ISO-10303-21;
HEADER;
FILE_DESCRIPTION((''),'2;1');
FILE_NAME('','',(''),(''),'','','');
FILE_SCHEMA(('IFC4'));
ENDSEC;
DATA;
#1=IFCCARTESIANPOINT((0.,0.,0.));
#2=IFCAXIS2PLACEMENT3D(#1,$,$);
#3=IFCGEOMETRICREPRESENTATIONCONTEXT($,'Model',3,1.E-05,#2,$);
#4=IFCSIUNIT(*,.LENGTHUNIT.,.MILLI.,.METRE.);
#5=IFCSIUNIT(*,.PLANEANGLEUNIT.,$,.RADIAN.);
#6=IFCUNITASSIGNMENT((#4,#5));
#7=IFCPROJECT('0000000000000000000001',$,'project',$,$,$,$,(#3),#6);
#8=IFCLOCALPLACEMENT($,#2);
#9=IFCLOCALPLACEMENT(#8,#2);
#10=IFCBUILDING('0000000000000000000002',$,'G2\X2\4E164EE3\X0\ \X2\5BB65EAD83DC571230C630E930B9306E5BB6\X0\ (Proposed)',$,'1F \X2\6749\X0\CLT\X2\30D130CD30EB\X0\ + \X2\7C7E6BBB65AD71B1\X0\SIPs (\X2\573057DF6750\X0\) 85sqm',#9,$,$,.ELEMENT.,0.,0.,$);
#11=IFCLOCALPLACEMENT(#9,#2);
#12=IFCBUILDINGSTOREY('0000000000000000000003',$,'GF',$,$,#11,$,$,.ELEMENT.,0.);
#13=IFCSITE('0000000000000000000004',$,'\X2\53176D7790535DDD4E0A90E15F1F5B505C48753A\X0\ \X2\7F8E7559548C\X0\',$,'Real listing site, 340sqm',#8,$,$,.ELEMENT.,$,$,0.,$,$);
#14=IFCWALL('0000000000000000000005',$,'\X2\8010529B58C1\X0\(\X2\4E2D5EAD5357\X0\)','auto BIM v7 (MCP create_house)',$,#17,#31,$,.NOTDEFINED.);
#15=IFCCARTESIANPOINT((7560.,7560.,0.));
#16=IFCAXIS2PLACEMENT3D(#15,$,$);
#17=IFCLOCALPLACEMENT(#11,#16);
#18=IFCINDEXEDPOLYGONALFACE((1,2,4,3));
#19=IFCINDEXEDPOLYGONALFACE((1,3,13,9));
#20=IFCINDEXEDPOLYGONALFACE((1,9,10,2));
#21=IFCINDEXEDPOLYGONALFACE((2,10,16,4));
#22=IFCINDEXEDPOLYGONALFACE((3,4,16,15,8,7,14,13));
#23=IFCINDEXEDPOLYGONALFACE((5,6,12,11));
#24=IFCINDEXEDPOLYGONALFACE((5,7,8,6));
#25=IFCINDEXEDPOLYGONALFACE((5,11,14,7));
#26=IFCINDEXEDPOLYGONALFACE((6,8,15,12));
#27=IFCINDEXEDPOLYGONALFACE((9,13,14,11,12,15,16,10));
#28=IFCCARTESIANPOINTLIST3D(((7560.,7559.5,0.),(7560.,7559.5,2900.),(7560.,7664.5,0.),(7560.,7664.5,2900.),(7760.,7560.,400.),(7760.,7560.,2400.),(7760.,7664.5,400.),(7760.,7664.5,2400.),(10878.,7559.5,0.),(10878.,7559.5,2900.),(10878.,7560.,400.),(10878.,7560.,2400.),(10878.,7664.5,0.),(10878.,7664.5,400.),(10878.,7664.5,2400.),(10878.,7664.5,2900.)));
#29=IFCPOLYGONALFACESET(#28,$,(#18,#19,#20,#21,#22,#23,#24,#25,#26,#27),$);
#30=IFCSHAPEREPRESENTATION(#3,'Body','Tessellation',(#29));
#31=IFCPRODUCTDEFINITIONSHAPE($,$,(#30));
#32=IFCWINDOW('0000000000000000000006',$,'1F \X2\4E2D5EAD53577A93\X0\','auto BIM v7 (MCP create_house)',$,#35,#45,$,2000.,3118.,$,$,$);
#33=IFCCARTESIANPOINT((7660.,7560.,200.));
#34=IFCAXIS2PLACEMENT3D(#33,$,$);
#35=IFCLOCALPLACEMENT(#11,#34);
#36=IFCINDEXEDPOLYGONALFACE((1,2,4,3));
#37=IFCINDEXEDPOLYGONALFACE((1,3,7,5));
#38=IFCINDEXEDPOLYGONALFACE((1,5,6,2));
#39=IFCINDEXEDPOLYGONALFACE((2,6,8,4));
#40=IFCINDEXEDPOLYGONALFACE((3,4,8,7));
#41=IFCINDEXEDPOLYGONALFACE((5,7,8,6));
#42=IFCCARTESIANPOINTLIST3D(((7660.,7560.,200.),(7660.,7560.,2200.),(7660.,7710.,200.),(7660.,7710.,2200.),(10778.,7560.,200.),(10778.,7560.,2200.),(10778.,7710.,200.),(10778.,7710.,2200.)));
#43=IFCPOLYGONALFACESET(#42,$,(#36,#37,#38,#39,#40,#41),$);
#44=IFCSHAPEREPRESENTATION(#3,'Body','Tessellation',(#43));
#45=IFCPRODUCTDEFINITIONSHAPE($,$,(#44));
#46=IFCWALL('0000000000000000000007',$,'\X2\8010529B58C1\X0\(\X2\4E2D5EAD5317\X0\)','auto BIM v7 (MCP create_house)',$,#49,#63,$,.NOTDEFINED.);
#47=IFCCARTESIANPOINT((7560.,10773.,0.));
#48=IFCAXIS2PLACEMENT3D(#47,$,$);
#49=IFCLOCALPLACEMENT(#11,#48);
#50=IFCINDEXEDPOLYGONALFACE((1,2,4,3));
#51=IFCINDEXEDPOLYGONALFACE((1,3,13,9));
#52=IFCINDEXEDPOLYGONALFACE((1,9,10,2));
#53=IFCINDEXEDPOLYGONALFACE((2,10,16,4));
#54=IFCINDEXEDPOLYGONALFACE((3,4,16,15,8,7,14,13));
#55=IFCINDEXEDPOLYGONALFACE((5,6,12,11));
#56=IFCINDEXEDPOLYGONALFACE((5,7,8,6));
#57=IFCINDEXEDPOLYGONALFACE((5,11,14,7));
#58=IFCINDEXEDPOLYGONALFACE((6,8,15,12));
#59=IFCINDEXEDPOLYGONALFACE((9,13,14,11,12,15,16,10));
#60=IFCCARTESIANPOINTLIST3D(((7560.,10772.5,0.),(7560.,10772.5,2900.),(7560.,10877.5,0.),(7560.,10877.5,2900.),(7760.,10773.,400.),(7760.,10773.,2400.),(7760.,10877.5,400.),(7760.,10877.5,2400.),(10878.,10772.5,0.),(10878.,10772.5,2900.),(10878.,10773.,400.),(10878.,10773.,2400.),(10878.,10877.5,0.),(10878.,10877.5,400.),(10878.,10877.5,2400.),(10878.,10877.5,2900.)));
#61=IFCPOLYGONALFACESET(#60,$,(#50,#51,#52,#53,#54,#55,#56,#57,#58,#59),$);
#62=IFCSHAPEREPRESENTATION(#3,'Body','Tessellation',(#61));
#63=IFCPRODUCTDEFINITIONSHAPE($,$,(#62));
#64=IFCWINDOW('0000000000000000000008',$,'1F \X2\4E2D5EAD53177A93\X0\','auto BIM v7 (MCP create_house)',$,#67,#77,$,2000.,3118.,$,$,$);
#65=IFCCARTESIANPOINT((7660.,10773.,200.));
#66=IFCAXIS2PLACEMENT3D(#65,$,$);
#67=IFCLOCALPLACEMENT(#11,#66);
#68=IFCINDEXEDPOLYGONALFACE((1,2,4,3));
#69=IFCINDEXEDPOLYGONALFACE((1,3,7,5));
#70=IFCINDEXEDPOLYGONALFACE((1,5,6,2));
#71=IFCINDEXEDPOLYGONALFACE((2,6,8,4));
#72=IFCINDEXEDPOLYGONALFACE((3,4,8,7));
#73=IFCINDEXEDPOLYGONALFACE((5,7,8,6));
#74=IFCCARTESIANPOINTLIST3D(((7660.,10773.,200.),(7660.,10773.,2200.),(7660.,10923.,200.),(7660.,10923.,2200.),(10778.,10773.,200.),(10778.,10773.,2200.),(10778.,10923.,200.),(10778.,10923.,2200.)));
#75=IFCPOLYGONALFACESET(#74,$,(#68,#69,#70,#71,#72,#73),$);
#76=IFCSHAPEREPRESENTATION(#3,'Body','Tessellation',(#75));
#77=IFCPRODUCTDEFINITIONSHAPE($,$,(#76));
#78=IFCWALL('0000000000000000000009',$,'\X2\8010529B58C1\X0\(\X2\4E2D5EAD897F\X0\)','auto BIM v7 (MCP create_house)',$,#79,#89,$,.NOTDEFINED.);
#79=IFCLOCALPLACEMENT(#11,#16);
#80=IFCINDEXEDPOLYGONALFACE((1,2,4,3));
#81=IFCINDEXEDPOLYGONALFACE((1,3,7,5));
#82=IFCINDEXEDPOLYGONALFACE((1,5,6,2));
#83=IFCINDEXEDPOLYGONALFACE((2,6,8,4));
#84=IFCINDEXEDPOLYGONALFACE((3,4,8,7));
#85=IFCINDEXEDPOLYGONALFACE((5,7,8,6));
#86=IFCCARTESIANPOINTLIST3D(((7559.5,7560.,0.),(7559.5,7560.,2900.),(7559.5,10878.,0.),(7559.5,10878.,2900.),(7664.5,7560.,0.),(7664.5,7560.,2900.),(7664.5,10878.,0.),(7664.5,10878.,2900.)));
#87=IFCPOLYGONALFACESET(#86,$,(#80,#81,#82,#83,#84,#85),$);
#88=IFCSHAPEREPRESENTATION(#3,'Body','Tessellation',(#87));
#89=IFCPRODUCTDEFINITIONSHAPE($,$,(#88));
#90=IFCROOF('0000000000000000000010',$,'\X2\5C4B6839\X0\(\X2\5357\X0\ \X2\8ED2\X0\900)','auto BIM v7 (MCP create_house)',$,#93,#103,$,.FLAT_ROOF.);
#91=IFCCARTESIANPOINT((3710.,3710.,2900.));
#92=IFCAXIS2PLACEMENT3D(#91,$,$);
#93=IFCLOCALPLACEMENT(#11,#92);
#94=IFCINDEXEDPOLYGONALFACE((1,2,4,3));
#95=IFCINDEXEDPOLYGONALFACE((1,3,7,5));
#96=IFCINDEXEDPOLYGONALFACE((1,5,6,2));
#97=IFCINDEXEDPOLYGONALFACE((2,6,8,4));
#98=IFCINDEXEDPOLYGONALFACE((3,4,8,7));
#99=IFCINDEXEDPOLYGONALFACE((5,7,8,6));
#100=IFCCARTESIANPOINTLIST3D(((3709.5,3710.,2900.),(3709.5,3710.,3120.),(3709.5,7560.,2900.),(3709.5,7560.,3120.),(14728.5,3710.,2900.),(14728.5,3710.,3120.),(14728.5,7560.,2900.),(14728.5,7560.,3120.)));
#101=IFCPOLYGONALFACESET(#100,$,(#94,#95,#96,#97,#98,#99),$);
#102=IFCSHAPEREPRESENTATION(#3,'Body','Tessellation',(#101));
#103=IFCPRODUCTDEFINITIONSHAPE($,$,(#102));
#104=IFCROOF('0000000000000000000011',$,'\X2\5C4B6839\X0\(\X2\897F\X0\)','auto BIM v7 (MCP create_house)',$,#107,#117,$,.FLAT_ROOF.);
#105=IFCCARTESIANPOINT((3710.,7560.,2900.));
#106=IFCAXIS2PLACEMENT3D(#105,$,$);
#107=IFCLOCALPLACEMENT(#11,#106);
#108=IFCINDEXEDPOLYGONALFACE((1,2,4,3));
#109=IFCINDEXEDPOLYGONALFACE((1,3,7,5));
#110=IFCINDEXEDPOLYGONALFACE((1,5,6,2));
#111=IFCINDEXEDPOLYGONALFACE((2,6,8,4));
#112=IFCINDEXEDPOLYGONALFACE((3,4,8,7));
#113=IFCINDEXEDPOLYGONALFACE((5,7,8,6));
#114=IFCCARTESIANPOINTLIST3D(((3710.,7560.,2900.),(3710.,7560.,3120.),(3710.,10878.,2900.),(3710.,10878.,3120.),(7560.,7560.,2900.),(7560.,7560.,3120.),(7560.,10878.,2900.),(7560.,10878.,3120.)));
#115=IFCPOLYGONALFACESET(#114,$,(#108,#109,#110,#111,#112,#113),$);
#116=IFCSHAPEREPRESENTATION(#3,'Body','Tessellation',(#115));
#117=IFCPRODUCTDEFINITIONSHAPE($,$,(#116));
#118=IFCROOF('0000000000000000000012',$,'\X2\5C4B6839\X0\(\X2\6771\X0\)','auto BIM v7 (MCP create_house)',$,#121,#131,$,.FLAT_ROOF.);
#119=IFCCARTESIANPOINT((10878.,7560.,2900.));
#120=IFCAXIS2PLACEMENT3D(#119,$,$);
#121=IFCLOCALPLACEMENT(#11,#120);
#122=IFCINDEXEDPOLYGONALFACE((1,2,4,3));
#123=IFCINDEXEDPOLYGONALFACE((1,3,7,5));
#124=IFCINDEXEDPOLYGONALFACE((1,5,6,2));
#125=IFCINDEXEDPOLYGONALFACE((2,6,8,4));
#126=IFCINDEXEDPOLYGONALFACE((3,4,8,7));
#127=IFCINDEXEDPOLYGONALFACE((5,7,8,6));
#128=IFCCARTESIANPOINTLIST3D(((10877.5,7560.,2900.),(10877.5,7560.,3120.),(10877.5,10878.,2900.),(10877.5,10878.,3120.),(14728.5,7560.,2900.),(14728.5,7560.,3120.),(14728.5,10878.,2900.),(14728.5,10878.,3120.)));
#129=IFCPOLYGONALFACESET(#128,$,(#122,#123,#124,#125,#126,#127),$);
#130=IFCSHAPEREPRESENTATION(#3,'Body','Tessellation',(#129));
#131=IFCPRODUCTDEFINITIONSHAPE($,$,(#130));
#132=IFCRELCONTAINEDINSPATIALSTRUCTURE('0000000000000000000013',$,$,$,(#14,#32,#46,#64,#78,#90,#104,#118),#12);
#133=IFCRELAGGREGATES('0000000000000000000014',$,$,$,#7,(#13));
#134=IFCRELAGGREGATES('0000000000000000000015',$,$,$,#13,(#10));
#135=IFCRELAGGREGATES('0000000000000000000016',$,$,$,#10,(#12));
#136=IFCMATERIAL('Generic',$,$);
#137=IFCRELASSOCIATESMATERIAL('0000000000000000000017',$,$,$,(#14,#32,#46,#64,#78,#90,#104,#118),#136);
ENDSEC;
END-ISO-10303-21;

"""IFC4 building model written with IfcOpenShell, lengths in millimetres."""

from ifc_helpers import new_model, si_unit, frame, frame_2d, origin, place, context, project, spatial, rectangle, extrude, material, element, fill, save


model = new_model("IFC4")

# Units and contexts
model_context = context("Model", 3, precision=1e-05, world=origin())
ifc_project = project(units=[si_unit("LENGTHUNIT", "METRE", prefix="MILLI"), si_unit("PLANEANGLEUNIT", "RADIAN")], contexts=[model_context])

# Site, building, storey
site_placement = place(None, origin())
site = spatial("IfcSite", under=ifc_project, at=site_placement, Name="北海道川上郡弟子屈町 美留和", ObjectType="Real listing site, 340sqm", CompositionType="ELEMENT", RefElevation=0.0)
building_placement = place(site_placement, origin())
building = spatial("IfcBuilding", under=site, at=building_placement, Name="G2世代 家庭菜園テラスの家 (Proposed)", ObjectType="1F 杉CLTパネル + 籾殻断熱SIPs (地域材) 85sqm", CompositionType="ELEMENT", ElevationOfRefHeight=0.0, ElevationOfTerrain=0.0)
storey_placement = place(building_placement, origin())
storey = spatial("IfcBuildingStorey", under=building, at=storey_placement, Name="GF", CompositionType="ELEMENT", Elevation=0.0)

# Shared definitions
ifc_material = material(Name="Generic")

# Walls, openings, windows
wall_1_placement = place(storey_placement, frame((7560.0, 7560.0, 0.0)))
wall_1 = element("IfcWall", 1, at=wall_1_placement, inside=storey, material=ifc_material, Name="耐力壁(中庭南)", Description="auto BIM v7 (MCP create_house)", PredefinedType="NOTDEFINED", context=model_context, shape_type="SweptSolid", body=[
    extrude(rectangle(XDim=3318.0, YDim=105.0, at=frame_2d((1659.0, 52.0))), frame((7560.0, 7560.0, 0.0)), (0.0, 0.0, 1.0), 2900.0),
])
opening_1_placement = place(storey_placement, frame((7660.0, 7560.0, 200.0)))
opening_1 = element("IfcOpeningElement", 2, at=opening_1_placement, cuts=wall_1, PredefinedType="NOTDEFINED", context=model_context, shape_type="SweptSolid", body=[
    extrude(rectangle(XDim=3118.0, YDim=150.0, at=frame_2d((1559.0, 75.0))), frame((7660.0, 7560.0, 200.0)), (0.0, 0.0, 1.0), 2000.0),
])
window_1_placement = place(storey_placement, frame((7660.0, 7560.0, 200.0)))
window_1 = element("IfcWindow", 3, at=window_1_placement, inside=storey, material=ifc_material, Name="1F 中庭南窓", Description="auto BIM v7 (MCP create_house)", OverallHeight=2000.0, OverallWidth=3118.0, context=model_context, shape_type="SweptSolid", body=[
    extrude(rectangle(XDim=3118.0, YDim=150.0, at=frame_2d((1559.0, 75.0))), frame((7660.0, 7560.0, 200.0)), (0.0, 0.0, 1.0), 2000.0),
])
fill(opening_1, window_1)
wall_2_placement = place(storey_placement, frame((7560.0, 10773.0, 0.0)))
wall_2 = element("IfcWall", 4, at=wall_2_placement, inside=storey, material=ifc_material, Name="耐力壁(中庭北)", Description="auto BIM v7 (MCP create_house)", PredefinedType="NOTDEFINED", context=model_context, shape_type="SweptSolid", body=[
    extrude(rectangle(XDim=3318.0, YDim=105.0, at=frame_2d((1659.0, 52.0))), frame((7560.0, 10773.0, 0.0)), (0.0, 0.0, 1.0), 2900.0),
])
opening_2_placement = place(storey_placement, frame((7660.0, 10773.0, 200.0)))
opening_2 = element("IfcOpeningElement", 5, at=opening_2_placement, cuts=wall_2, PredefinedType="NOTDEFINED", context=model_context, shape_type="SweptSolid", body=[
    extrude(rectangle(XDim=3118.0, YDim=150.0, at=frame_2d((1559.0, 75.0))), frame((7660.0, 10773.0, 200.0)), (0.0, 0.0, 1.0), 2000.0),
])
window_2_placement = place(storey_placement, frame((7660.0, 10773.0, 200.0)))
window_2 = element("IfcWindow", 6, at=window_2_placement, inside=storey, material=ifc_material, Name="1F 中庭北窓", Description="auto BIM v7 (MCP create_house)", OverallHeight=2000.0, OverallWidth=3118.0, context=model_context, shape_type="SweptSolid", body=[
    extrude(rectangle(XDim=3118.0, YDim=150.0, at=frame_2d((1559.0, 75.0))), frame((7660.0, 10773.0, 200.0)), (0.0, 0.0, 1.0), 2000.0),
])
fill(opening_2, window_2)

# Wall
wall_3_placement = place(storey_placement, frame((7560.0, 7560.0, 0.0)))
element("IfcWall", 7, at=wall_3_placement, inside=storey, material=ifc_material, Name="耐力壁(中庭西)", Description="auto BIM v7 (MCP create_house)", PredefinedType="NOTDEFINED", context=model_context, shape_type="SweptSolid", body=[
    extrude(rectangle(XDim=105.0, YDim=3318.0, at=frame_2d((52.0, 1659.0))), frame((7560.0, 7560.0, 0.0)), (0.0, 0.0, 1.0), 2900.0),
])

# Roofs
roof_1_placement = place(storey_placement, frame((3710.0, 3710.0, 2900.0)))
element("IfcRoof", 8, at=roof_1_placement, inside=storey, material=ifc_material, Name="屋根(南 軒900)", Description="auto BIM v7 (MCP create_house)", PredefinedType="FLAT_ROOF", context=model_context, shape_type="SweptSolid", body=[
    extrude(rectangle(XDim=11019.0, YDim=3850.0, at=frame_2d((5509.0, 1925.0))), frame((3710.0, 3710.0, 2900.0)), (0.0, 0.0, 1.0), 220.0),
])
roof_2_placement = place(storey_placement, frame((3710.0, 7560.0, 2900.0)))
element("IfcRoof", 9, at=roof_2_placement, inside=storey, material=ifc_material, Name="屋根(西)", Description="auto BIM v7 (MCP create_house)", PredefinedType="FLAT_ROOF", context=model_context, shape_type="SweptSolid", body=[
    extrude(rectangle(XDim=3850.0, YDim=3318.0, at=frame_2d((1925.0, 1659.0))), frame((3710.0, 7560.0, 2900.0)), (0.0, 0.0, 1.0), 220.0),
])
roof_3_placement = place(storey_placement, frame((10878.0, 7560.0, 2900.0)))
element("IfcRoof", 10, at=roof_3_placement, inside=storey, material=ifc_material, Name="屋根(東)", Description="auto BIM v7 (MCP create_house)", PredefinedType="FLAT_ROOF", context=model_context, shape_type="SweptSolid", body=[
    extrude(rectangle(XDim=3851.0, YDim=3318.0, at=frame_2d((1925.0, 1659.0))), frame((10878.0, 7560.0, 2900.0)), (0.0, 0.0, 1.0), 220.0),
])

save(model, "model.ifc")
